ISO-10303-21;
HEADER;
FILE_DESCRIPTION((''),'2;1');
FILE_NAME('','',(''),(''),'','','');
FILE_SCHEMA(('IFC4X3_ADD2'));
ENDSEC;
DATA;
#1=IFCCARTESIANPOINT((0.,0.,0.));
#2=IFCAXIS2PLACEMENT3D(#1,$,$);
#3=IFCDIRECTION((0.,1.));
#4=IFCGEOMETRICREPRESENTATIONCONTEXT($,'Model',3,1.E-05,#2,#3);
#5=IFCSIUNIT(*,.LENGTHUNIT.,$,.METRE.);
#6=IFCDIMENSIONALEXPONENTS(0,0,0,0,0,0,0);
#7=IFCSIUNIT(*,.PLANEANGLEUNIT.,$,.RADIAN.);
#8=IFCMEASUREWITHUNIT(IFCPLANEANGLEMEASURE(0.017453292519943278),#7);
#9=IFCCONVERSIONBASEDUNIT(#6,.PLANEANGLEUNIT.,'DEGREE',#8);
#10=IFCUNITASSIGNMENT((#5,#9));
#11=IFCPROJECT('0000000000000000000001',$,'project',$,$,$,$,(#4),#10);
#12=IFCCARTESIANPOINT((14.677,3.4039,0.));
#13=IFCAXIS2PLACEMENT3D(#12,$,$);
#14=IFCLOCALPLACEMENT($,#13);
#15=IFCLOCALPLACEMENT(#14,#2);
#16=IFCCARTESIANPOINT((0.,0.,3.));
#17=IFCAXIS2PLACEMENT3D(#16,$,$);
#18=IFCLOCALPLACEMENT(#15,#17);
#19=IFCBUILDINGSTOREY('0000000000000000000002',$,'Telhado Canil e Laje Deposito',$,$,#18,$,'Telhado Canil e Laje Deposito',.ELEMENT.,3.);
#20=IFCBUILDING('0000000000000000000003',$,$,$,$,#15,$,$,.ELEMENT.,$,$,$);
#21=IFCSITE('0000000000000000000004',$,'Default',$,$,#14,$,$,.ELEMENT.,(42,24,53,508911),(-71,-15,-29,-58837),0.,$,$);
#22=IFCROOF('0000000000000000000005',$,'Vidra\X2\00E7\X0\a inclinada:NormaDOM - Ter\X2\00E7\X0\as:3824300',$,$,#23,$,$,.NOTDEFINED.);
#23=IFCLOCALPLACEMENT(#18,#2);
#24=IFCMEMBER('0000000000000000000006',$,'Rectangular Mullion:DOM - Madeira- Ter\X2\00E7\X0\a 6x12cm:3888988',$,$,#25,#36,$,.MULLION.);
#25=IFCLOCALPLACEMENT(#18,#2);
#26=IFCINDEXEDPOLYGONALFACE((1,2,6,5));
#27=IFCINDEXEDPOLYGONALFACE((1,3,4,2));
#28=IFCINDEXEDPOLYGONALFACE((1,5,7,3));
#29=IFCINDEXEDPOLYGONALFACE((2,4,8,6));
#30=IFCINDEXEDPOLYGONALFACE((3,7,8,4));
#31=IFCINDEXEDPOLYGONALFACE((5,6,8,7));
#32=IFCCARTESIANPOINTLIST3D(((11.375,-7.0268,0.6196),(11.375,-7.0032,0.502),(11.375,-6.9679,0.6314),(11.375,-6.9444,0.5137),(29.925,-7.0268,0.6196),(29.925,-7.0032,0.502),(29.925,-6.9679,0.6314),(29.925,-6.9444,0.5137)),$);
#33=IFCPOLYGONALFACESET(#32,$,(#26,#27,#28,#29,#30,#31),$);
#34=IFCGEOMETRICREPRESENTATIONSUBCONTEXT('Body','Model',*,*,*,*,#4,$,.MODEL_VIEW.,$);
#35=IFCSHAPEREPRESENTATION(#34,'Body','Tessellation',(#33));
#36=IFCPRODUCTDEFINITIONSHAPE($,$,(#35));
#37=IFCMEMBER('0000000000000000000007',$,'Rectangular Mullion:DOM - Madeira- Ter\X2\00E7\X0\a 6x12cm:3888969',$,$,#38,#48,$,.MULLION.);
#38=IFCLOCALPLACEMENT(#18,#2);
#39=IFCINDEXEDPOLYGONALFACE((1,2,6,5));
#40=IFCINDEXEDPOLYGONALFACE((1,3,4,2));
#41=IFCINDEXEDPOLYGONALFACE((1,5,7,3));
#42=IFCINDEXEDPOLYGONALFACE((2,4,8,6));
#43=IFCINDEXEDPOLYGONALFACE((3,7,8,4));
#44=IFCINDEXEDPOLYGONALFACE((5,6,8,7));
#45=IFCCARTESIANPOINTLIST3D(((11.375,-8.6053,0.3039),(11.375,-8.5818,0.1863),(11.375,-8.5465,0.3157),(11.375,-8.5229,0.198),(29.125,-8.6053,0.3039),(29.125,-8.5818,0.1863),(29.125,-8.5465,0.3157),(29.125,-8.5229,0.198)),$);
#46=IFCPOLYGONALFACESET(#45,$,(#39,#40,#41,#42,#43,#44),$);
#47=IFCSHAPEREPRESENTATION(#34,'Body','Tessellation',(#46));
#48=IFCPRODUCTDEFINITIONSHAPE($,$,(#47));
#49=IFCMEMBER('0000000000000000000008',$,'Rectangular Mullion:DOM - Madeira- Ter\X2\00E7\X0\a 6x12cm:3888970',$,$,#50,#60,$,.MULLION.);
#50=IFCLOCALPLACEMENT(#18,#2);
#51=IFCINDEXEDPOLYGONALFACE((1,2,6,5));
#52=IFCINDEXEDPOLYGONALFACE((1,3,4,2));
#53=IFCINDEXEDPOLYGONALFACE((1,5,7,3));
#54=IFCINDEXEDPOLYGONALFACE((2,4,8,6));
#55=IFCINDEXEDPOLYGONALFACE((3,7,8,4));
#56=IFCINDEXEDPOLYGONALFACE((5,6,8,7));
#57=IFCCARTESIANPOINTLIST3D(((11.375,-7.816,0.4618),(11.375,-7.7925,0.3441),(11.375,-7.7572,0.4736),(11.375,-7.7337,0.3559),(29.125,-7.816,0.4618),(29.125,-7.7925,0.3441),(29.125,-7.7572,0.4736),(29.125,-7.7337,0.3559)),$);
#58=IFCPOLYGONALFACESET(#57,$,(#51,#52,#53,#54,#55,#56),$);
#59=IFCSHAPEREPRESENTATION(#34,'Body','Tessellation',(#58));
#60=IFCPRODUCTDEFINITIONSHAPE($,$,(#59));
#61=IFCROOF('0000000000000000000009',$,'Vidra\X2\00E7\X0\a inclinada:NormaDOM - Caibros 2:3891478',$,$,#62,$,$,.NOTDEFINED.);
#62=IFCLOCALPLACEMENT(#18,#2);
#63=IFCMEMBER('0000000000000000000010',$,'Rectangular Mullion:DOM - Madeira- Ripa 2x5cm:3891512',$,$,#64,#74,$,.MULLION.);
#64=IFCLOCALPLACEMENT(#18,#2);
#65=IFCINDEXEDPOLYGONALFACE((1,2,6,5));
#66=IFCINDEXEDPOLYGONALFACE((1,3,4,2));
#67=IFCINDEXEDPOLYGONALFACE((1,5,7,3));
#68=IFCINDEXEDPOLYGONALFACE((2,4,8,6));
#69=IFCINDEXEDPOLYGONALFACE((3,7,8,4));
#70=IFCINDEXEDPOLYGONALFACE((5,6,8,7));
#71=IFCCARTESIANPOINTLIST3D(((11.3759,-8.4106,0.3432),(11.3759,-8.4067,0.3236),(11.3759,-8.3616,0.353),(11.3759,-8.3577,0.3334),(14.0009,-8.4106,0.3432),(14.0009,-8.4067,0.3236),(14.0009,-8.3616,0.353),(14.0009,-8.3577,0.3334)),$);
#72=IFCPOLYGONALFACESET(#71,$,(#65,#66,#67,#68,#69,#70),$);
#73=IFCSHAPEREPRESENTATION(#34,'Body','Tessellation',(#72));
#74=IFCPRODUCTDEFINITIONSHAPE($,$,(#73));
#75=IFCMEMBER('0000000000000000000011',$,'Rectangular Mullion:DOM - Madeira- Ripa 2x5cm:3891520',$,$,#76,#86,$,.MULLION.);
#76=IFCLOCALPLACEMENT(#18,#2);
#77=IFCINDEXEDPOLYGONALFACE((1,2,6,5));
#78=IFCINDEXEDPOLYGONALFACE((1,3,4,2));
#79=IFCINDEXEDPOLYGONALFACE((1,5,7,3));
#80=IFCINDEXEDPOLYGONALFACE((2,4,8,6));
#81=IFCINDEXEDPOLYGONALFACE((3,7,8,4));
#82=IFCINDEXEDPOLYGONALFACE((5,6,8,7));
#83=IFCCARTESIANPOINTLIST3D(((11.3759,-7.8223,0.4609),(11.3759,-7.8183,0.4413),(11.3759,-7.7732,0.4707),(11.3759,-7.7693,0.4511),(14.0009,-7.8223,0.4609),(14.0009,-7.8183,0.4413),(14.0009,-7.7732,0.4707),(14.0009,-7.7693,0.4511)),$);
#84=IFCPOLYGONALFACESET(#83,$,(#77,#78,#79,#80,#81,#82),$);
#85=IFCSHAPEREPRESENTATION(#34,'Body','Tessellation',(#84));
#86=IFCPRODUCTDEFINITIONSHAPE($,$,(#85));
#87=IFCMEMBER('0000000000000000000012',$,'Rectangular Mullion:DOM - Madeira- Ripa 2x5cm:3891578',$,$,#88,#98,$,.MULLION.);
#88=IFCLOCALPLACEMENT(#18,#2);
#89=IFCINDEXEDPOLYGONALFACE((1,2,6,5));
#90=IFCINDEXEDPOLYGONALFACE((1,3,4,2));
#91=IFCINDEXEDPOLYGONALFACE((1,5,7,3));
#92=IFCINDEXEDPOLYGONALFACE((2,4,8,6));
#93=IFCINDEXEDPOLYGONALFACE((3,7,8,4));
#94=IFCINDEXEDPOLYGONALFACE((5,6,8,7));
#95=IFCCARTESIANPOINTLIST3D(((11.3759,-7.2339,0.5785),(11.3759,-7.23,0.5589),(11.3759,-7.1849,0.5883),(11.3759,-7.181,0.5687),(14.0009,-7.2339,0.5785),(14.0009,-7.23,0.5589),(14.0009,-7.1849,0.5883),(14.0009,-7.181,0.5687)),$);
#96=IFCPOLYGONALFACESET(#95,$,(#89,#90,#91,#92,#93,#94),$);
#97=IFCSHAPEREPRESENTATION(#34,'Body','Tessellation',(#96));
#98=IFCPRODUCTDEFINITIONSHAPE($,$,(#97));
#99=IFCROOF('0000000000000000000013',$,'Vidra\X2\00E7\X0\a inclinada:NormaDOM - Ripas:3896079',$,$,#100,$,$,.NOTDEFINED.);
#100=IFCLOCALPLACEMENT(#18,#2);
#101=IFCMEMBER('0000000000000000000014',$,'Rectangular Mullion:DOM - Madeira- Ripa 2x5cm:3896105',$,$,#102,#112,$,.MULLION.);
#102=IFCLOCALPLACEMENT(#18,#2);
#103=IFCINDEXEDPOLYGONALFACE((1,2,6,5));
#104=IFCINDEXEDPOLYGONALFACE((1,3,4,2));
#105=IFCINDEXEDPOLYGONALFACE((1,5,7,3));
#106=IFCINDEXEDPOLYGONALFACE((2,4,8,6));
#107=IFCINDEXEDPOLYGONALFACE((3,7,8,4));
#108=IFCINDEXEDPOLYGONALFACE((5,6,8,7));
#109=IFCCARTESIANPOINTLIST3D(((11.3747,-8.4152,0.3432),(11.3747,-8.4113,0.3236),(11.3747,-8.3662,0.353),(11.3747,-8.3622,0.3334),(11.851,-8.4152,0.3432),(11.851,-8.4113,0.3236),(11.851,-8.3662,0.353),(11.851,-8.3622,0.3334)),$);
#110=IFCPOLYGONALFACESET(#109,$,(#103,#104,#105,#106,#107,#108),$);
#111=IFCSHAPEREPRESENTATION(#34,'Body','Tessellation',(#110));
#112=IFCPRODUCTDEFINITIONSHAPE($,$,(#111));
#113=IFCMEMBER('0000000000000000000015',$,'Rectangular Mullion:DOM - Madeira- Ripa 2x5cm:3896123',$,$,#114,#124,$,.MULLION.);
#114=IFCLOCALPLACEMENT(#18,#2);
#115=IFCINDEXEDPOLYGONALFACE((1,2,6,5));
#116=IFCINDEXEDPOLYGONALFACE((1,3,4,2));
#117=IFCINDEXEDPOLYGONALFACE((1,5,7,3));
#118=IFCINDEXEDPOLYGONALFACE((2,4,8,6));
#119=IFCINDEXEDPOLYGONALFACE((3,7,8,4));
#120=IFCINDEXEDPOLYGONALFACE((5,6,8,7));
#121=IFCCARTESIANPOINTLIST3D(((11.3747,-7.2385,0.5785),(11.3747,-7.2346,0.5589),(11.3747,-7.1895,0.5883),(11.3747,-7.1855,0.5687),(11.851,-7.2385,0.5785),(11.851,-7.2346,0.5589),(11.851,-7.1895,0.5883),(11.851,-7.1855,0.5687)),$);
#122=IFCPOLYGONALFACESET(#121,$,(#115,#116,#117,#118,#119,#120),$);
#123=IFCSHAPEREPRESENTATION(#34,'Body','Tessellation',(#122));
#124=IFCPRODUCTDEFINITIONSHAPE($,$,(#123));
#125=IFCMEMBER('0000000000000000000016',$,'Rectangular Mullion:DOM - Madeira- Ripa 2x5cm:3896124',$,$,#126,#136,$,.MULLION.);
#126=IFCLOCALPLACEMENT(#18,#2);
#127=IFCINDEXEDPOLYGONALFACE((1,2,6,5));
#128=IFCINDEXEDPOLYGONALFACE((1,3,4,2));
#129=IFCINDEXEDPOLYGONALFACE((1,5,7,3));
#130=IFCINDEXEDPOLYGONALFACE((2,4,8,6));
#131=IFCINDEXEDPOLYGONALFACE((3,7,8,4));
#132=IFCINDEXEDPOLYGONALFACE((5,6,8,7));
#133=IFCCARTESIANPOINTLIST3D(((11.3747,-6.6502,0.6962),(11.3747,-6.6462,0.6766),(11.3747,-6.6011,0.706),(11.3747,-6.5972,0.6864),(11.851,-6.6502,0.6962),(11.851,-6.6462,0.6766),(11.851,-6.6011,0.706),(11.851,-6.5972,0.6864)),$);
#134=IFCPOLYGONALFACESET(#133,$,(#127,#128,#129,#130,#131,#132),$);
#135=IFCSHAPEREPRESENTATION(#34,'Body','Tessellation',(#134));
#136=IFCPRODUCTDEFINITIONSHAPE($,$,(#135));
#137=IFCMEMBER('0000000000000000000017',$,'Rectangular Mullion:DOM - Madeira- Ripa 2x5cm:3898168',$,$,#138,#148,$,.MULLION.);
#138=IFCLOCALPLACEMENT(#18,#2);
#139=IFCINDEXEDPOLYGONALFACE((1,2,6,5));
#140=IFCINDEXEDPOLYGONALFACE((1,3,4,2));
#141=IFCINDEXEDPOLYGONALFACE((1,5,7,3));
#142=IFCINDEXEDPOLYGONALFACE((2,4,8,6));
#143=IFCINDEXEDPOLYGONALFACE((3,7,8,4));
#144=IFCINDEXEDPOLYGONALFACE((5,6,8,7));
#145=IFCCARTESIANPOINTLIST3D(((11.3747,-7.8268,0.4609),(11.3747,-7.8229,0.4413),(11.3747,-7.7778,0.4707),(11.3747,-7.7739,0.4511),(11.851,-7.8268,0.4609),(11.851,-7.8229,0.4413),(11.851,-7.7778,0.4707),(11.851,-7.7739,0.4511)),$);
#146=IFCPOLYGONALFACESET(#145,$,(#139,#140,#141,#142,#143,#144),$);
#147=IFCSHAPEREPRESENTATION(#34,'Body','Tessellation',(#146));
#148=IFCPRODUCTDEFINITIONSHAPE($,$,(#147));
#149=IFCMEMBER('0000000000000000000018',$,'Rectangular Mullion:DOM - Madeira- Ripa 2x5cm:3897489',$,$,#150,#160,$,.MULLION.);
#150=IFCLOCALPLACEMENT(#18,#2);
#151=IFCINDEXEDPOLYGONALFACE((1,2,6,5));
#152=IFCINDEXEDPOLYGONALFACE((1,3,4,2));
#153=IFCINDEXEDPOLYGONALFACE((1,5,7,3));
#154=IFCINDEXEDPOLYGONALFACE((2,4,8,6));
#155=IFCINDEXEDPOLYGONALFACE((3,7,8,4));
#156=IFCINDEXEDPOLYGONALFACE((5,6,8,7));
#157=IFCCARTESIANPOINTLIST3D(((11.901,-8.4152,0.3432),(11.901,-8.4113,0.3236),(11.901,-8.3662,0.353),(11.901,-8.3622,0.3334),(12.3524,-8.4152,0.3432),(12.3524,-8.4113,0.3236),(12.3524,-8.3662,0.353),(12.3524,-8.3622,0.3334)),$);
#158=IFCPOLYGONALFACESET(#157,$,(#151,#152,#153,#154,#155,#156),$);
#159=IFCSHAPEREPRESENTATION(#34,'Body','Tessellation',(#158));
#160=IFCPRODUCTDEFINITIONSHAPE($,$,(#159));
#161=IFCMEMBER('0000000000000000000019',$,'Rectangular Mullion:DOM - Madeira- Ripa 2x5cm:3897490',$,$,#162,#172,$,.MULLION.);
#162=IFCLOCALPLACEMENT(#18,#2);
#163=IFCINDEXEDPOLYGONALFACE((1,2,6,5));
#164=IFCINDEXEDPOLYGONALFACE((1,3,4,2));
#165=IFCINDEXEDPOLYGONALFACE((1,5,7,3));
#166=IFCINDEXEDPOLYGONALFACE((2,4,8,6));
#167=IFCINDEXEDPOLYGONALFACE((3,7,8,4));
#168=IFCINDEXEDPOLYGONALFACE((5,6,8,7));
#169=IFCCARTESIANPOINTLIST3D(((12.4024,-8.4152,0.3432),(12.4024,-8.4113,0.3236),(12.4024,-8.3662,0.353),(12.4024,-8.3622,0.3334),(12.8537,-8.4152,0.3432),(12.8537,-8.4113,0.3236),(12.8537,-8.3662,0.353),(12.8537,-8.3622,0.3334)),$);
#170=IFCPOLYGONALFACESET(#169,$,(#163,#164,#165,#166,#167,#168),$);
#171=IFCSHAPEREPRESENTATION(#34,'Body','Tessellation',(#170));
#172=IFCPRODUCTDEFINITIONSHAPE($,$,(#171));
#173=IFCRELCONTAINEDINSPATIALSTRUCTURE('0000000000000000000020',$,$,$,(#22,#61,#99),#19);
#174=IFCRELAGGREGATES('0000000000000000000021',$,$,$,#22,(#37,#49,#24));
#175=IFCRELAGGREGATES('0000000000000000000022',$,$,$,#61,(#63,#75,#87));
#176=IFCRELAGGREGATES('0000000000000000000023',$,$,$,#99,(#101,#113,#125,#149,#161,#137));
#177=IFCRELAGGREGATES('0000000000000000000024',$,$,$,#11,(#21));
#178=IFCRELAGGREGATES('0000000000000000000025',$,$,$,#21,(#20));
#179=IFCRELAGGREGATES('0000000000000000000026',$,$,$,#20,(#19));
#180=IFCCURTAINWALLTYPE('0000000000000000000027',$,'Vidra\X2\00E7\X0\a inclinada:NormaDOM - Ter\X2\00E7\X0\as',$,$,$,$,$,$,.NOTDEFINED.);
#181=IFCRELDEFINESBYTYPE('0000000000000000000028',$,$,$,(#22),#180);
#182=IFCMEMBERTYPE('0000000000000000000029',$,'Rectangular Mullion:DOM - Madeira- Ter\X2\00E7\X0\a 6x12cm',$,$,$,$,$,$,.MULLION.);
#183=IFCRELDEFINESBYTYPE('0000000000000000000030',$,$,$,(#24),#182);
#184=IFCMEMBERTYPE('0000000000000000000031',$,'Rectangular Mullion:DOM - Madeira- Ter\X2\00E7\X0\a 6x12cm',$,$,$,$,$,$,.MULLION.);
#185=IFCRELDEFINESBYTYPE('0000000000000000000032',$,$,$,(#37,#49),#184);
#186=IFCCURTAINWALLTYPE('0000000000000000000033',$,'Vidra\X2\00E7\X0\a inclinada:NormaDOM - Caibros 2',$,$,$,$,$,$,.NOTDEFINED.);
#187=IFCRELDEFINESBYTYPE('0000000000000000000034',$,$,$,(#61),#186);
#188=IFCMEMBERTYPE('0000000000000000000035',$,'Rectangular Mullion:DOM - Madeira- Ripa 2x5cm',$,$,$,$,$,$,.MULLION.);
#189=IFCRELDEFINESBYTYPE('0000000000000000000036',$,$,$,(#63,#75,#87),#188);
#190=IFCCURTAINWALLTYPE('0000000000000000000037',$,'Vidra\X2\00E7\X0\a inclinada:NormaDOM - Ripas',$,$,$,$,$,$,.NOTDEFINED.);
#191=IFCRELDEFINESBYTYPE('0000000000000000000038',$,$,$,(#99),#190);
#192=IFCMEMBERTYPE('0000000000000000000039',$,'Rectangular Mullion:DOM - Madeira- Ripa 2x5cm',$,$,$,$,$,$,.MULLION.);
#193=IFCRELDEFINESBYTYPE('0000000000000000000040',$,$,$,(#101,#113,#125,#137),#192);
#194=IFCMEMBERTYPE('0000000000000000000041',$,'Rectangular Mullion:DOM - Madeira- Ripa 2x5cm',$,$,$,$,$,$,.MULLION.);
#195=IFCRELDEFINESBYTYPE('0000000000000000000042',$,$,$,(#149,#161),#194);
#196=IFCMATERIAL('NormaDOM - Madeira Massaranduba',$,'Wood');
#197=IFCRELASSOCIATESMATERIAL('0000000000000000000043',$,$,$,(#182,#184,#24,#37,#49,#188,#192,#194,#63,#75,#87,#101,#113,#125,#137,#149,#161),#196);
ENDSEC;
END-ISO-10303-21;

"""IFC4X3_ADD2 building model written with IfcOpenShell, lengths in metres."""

from ifc_helpers import new_model, entity, si_unit, converted_unit, direction, frame, origin, origin_2d_with_axis, place, context, subcontext, project, spatial, rectangle, extrude, source, transform, mapped, material, material_profile, profile_set, profile_usage, type_object, type_shapes, element, aggregate, save


model = new_model("IFC4X3_ADD2")

# Units and contexts
model_context = context("Model", 3, precision=1e-05, world=origin(), true_north=direction((0.0, 1.0)))
body_context = subcontext(model_context, "Body", "Model", "MODEL_VIEW")
ifc_project = project(units=[si_unit("LENGTHUNIT", "METRE"), converted_unit("PLANEANGLEUNIT", "DEGREE", entity("IfcPlaneAngleMeasure", 0.017453292519943278), si_unit("PLANEANGLEUNIT", "RADIAN"), dimensions=[0, 0, 0, 0, 0, 0, 0])], contexts=[model_context])

# Site, building, storey
site_placement = place(None, frame((14.677, 3.4039, 0.0)))
site = spatial("IfcSite", under=ifc_project, at=site_placement, Name="Default", CompositionType="ELEMENT", RefLatitude=(42, 24, 53, 508911), RefLongitude=(-71, -15, -29, -58837), RefElevation=0.0)
building_placement = place(site_placement, origin())
building = spatial("IfcBuilding", under=site, at=building_placement, CompositionType="ELEMENT")
storey_placement = place(building_placement, frame((0.0, 0.0, 3.0)))
storey = spatial("IfcBuildingStorey", under=building, at=storey_placement, Name="Telhado Canil e Laje Deposito", LongName="Telhado Canil e Laje Deposito", CompositionType="ELEMENT", Elevation=3.0)

# Roofs, members
curtain_wall_type_1 = type_object("IfcCurtainWallType", Name="Vidraça inclinada:NormaDOM - Terças", PredefinedType="NOTDEFINED")
roof_1_placement = place(storey_placement, frame((0.0, 0.0, -3.0)))
roof_1 = element("IfcRoof", 1, at=roof_1_placement, inside=storey, type_object=curtain_wall_type_1, Name="Vidraça inclinada:NormaDOM - Terças:3824300", PredefinedType="NOTDEFINED")
ifc_material = material(Name="NormaDOM - Madeira Massaranduba", Category="Wood")
ifc_material_profile_1 = material_profile(ifc_material, rectangle(XDim=0.06, YDim=0.12, at=origin_2d_with_axis()), Name="DOM - Madeira- Terça 6x12cm")
ifc_profile_set_1 = profile_set([ifc_material_profile_1], Name="DOM - Madeira- Terça 6x12cm")
ifc_profile_usage_1 = profile_usage(ifc_profile_set_1)
member_type_1 = type_object("IfcMemberType", Name="Rectangular Mullion:DOM - Madeira- Terça 6x12cm", PredefinedType="MULLION", material=ifc_profile_set_1)
shared_shape_1 = source(origin(), body_context, "Body", "SweptSolid", [
    extrude(rectangle(XDim=0.06, YDim=0.12, at=origin_2d_with_axis()), frame((0.0, 0.06, -18.55), z_axis=(0.0, 0.0, 1.0), x_axis=(-1.0, 0.0, 0.0)), (0.0, 0.0, 1.0), 18.55),
])
type_shapes(member_type_1, [shared_shape_1])
member_1_placement = place(roof_1_placement, frame((11.375, -6.9973, 3.6255), z_axis=(-1.0, 0.0, 0.0), x_axis=(0.0, 0.980581, 0.196116)))
member_1 = element("IfcMember", 2, at=member_1_placement, type_object=member_type_1, material=ifc_profile_usage_1, Name="Rectangular Mullion:DOM - Madeira- Terça 6x12cm:3888988", PredefinedType="MULLION", context=body_context, shape_type="MappedRepresentation", body=[
    mapped(shared_shape_1, transform((0.0, 0.0, 0.0), scale=1.0)),
])
member_type_2 = type_object("IfcMemberType", Name="Rectangular Mullion:DOM - Madeira- Terça 6x12cm", PredefinedType="MULLION", material=ifc_profile_set_1)
shared_shape_2 = source(origin(), body_context, "Body", "SweptSolid", [
    extrude(rectangle(XDim=0.06, YDim=0.12, at=origin_2d_with_axis()), frame((0.0, 0.06, -17.75), z_axis=(0.0, 0.0, 1.0), x_axis=(-1.0, 0.0, 0.0)), (0.0, 0.0, 1.0), 17.75),
])
type_shapes(member_type_2, [shared_shape_2])
member_2_placement = place(roof_1_placement, frame((11.375, -8.5759, 3.3098), z_axis=(-1.0, 0.0, 0.0), x_axis=(0.0, 0.980581, 0.196116)))
member_2 = element("IfcMember", 3, at=member_2_placement, type_object=member_type_2, material=ifc_profile_usage_1, Name="Rectangular Mullion:DOM - Madeira- Terça 6x12cm:3888969", PredefinedType="MULLION", context=body_context, shape_type="MappedRepresentation", body=[
    mapped(shared_shape_2, transform((0.0, 0.0, 0.0), scale=1.0)),
])
member_3_placement = place(roof_1_placement, frame((11.375, -7.7866, 3.4677), z_axis=(-1.0, 0.0, 0.0), x_axis=(0.0, 0.980581, 0.196116)))
member_3 = element("IfcMember", 4, at=member_3_placement, type_object=member_type_2, material=ifc_profile_usage_1, Name="Rectangular Mullion:DOM - Madeira- Terça 6x12cm:3888970", PredefinedType="MULLION", context=body_context, shape_type="MappedRepresentation", body=[
    mapped(shared_shape_2, transform((0.0, 0.0, 0.0), scale=1.0)),
])
aggregate(roof_1, [member_2, member_3, member_1])
curtain_wall_type_2 = type_object("IfcCurtainWallType", Name="Vidraça inclinada:NormaDOM - Caibros 2", PredefinedType="NOTDEFINED")
roof_2_placement = place(storey_placement, frame((0.0, 0.0, -3.0)))
roof_2 = element("IfcRoof", 5, at=roof_2_placement, inside=storey, type_object=curtain_wall_type_2, Name="Vidraça inclinada:NormaDOM - Caibros 2:3891478", PredefinedType="NOTDEFINED")
ifc_material_profile_2 = material_profile(ifc_material, rectangle(XDim=0.05, YDim=0.02, at=origin_2d_with_axis()), Name="DOM - Madeira- Ripa 2x5cm")
ifc_profile_set_2 = profile_set([ifc_material_profile_2], Name="DOM - Madeira- Ripa 2x5cm")
ifc_profile_usage_2 = profile_usage(ifc_profile_set_2)
member_type_3 = type_object("IfcMemberType", Name="Rectangular Mullion:DOM - Madeira- Ripa 2x5cm", PredefinedType="MULLION", material=ifc_profile_set_2)
shared_shape_3 = source(origin(), body_context, "Body", "SweptSolid", [
    extrude(rectangle(XDim=0.05, YDim=0.02, at=origin_2d_with_axis()), frame((0.025, 0.01, -2.625), z_axis=(0.0, 0.0, 1.0), x_axis=(-1.0, 0.0, 0.0)), (0.0, 0.0, 1.0), 2.625),
])
type_shapes(member_type_3, [shared_shape_3])
member_4_placement = place(roof_2_placement, frame((11.3759, -8.4106, 3.3432), z_axis=(-1.0, 0.0, 0.0), x_axis=(0.0, 0.980581, 0.196116)))
member_4 = element("IfcMember", 6, at=member_4_placement, type_object=member_type_3, material=ifc_profile_usage_2, Name="Rectangular Mullion:DOM - Madeira- Ripa 2x5cm:3891512", PredefinedType="MULLION", context=body_context, shape_type="MappedRepresentation", body=[
    mapped(shared_shape_3, transform((0.0, 0.0, 0.0), scale=1.0)),
])
member_5_placement = place(roof_2_placement, frame((11.3759, -7.8223, 3.4609), z_axis=(-1.0, 0.0, 0.0), x_axis=(0.0, 0.980581, 0.196116)))
member_5 = element("IfcMember", 7, at=member_5_placement, type_object=member_type_3, material=ifc_profile_usage_2, Name="Rectangular Mullion:DOM - Madeira- Ripa 2x5cm:3891520", PredefinedType="MULLION", context=body_context, shape_type="MappedRepresentation", body=[
    mapped(shared_shape_3, transform((0.0, 0.0, 0.0), scale=1.0)),
])
member_6_placement = place(roof_2_placement, frame((11.3759, -7.2339, 3.5785), z_axis=(-1.0, 0.0, 0.0), x_axis=(0.0, 0.980581, 0.196116)))
member_6 = element("IfcMember", 8, at=member_6_placement, type_object=member_type_3, material=ifc_profile_usage_2, Name="Rectangular Mullion:DOM - Madeira- Ripa 2x5cm:3891578", PredefinedType="MULLION", context=body_context, shape_type="MappedRepresentation", body=[
    mapped(shared_shape_3, transform((0.0, 0.0, 0.0), scale=1.0)),
])
aggregate(roof_2, [member_4, member_5, member_6])
curtain_wall_type_3 = type_object("IfcCurtainWallType", Name="Vidraça inclinada:NormaDOM - Ripas", PredefinedType="NOTDEFINED")
roof_3_placement = place(storey_placement, frame((0.0, 0.0, -3.0)))
roof_3 = element("IfcRoof", 9, at=roof_3_placement, inside=storey, type_object=curtain_wall_type_3, Name="Vidraça inclinada:NormaDOM - Ripas:3896079", PredefinedType="NOTDEFINED")
member_type_4 = type_object("IfcMemberType", Name="Rectangular Mullion:DOM - Madeira- Ripa 2x5cm", PredefinedType="MULLION", material=ifc_profile_set_2)
shared_shape_4 = source(origin(), body_context, "Body", "SweptSolid", [
    extrude(rectangle(XDim=0.05, YDim=0.02, at=origin_2d_with_axis()), frame((0.025, 0.01, -0.4764), z_axis=(0.0, 0.0, 1.0), x_axis=(-1.0, 0.0, 0.0)), (0.0, 0.0, 1.0), 0.4764),
])
type_shapes(member_type_4, [shared_shape_4])
member_7_placement = place(roof_3_placement, frame((11.3747, -8.4152, 3.3432), z_axis=(-1.0, 0.0, 0.0), x_axis=(0.0, 0.980581, 0.196116)))
member_7 = element("IfcMember", 10, at=member_7_placement, type_object=member_type_4, material=ifc_profile_usage_2, Name="Rectangular Mullion:DOM - Madeira- Ripa 2x5cm:3896105", PredefinedType="MULLION", context=body_context, shape_type="MappedRepresentation", body=[
    mapped(shared_shape_4, transform((0.0, 0.0, 0.0), scale=1.0)),
])
member_8_placement = place(roof_3_placement, frame((11.3747, -7.2385, 3.5785), z_axis=(-1.0, 0.0, 0.0), x_axis=(0.0, 0.980581, 0.196116)))
member_8 = element("IfcMember", 11, at=member_8_placement, type_object=member_type_4, material=ifc_profile_usage_2, Name="Rectangular Mullion:DOM - Madeira- Ripa 2x5cm:3896123", PredefinedType="MULLION", context=body_context, shape_type="MappedRepresentation", body=[
    mapped(shared_shape_4, transform((0.0, 0.0, 0.0), scale=1.0)),
])
member_9_placement = place(roof_3_placement, frame((11.3747, -6.6502, 3.6962), z_axis=(-1.0, 0.0, 0.0), x_axis=(0.0, 0.980581, 0.196116)))
member_9 = element("IfcMember", 12, at=member_9_placement, type_object=member_type_4, material=ifc_profile_usage_2, Name="Rectangular Mullion:DOM - Madeira- Ripa 2x5cm:3896124", PredefinedType="MULLION", context=body_context, shape_type="MappedRepresentation", body=[
    mapped(shared_shape_4, transform((0.0, 0.0, 0.0), scale=1.0)),
])
member_10_placement = place(roof_3_placement, frame((11.3747, -7.8268, 3.4609), z_axis=(-1.0, 0.0, 0.0), x_axis=(0.0, 0.980581, 0.196116)))
member_10 = element("IfcMember", 13, at=member_10_placement, type_object=member_type_4, material=ifc_profile_usage_2, Name="Rectangular Mullion:DOM - Madeira- Ripa 2x5cm:3898168", PredefinedType="MULLION", context=body_context, shape_type="MappedRepresentation", body=[
    mapped(shared_shape_4, transform((0.0, 0.0, 0.0), scale=1.0)),
])
member_type_5 = type_object("IfcMemberType", Name="Rectangular Mullion:DOM - Madeira- Ripa 2x5cm", PredefinedType="MULLION", material=ifc_profile_set_2)
shared_shape_5 = source(origin(), body_context, "Body", "SweptSolid", [
    extrude(rectangle(XDim=0.05, YDim=0.02, at=origin_2d_with_axis()), frame((0.025, 0.01, -0.4514), z_axis=(0.0, 0.0, 1.0), x_axis=(-1.0, 0.0, 0.0)), (0.0, 0.0, 1.0), 0.4514),
])
type_shapes(member_type_5, [shared_shape_5])
member_11_placement = place(roof_3_placement, frame((11.901, -8.4152, 3.3432), z_axis=(-1.0, 0.0, 0.0), x_axis=(0.0, 0.980581, 0.196116)))
member_11 = element("IfcMember", 14, at=member_11_placement, type_object=member_type_5, material=ifc_profile_usage_2, Name="Rectangular Mullion:DOM - Madeira- Ripa 2x5cm:3897489", PredefinedType="MULLION", context=body_context, shape_type="MappedRepresentation", body=[
    mapped(shared_shape_5, transform((0.0, 0.0, 0.0), scale=1.0)),
])
member_12_placement = place(roof_3_placement, frame((12.4024, -8.4152, 3.3432), z_axis=(-1.0, 0.0, 0.0), x_axis=(0.0, 0.980581, 0.196116)))
member_12 = element("IfcMember", 15, at=member_12_placement, type_object=member_type_5, material=ifc_profile_usage_2, Name="Rectangular Mullion:DOM - Madeira- Ripa 2x5cm:3897490", PredefinedType="MULLION", context=body_context, shape_type="MappedRepresentation", body=[
    mapped(shared_shape_5, transform((0.0, 0.0, 0.0), scale=1.0)),
])
aggregate(roof_3, [member_7, member_8, member_9, member_11, member_12, member_10])

save(model, "model.ifc")
